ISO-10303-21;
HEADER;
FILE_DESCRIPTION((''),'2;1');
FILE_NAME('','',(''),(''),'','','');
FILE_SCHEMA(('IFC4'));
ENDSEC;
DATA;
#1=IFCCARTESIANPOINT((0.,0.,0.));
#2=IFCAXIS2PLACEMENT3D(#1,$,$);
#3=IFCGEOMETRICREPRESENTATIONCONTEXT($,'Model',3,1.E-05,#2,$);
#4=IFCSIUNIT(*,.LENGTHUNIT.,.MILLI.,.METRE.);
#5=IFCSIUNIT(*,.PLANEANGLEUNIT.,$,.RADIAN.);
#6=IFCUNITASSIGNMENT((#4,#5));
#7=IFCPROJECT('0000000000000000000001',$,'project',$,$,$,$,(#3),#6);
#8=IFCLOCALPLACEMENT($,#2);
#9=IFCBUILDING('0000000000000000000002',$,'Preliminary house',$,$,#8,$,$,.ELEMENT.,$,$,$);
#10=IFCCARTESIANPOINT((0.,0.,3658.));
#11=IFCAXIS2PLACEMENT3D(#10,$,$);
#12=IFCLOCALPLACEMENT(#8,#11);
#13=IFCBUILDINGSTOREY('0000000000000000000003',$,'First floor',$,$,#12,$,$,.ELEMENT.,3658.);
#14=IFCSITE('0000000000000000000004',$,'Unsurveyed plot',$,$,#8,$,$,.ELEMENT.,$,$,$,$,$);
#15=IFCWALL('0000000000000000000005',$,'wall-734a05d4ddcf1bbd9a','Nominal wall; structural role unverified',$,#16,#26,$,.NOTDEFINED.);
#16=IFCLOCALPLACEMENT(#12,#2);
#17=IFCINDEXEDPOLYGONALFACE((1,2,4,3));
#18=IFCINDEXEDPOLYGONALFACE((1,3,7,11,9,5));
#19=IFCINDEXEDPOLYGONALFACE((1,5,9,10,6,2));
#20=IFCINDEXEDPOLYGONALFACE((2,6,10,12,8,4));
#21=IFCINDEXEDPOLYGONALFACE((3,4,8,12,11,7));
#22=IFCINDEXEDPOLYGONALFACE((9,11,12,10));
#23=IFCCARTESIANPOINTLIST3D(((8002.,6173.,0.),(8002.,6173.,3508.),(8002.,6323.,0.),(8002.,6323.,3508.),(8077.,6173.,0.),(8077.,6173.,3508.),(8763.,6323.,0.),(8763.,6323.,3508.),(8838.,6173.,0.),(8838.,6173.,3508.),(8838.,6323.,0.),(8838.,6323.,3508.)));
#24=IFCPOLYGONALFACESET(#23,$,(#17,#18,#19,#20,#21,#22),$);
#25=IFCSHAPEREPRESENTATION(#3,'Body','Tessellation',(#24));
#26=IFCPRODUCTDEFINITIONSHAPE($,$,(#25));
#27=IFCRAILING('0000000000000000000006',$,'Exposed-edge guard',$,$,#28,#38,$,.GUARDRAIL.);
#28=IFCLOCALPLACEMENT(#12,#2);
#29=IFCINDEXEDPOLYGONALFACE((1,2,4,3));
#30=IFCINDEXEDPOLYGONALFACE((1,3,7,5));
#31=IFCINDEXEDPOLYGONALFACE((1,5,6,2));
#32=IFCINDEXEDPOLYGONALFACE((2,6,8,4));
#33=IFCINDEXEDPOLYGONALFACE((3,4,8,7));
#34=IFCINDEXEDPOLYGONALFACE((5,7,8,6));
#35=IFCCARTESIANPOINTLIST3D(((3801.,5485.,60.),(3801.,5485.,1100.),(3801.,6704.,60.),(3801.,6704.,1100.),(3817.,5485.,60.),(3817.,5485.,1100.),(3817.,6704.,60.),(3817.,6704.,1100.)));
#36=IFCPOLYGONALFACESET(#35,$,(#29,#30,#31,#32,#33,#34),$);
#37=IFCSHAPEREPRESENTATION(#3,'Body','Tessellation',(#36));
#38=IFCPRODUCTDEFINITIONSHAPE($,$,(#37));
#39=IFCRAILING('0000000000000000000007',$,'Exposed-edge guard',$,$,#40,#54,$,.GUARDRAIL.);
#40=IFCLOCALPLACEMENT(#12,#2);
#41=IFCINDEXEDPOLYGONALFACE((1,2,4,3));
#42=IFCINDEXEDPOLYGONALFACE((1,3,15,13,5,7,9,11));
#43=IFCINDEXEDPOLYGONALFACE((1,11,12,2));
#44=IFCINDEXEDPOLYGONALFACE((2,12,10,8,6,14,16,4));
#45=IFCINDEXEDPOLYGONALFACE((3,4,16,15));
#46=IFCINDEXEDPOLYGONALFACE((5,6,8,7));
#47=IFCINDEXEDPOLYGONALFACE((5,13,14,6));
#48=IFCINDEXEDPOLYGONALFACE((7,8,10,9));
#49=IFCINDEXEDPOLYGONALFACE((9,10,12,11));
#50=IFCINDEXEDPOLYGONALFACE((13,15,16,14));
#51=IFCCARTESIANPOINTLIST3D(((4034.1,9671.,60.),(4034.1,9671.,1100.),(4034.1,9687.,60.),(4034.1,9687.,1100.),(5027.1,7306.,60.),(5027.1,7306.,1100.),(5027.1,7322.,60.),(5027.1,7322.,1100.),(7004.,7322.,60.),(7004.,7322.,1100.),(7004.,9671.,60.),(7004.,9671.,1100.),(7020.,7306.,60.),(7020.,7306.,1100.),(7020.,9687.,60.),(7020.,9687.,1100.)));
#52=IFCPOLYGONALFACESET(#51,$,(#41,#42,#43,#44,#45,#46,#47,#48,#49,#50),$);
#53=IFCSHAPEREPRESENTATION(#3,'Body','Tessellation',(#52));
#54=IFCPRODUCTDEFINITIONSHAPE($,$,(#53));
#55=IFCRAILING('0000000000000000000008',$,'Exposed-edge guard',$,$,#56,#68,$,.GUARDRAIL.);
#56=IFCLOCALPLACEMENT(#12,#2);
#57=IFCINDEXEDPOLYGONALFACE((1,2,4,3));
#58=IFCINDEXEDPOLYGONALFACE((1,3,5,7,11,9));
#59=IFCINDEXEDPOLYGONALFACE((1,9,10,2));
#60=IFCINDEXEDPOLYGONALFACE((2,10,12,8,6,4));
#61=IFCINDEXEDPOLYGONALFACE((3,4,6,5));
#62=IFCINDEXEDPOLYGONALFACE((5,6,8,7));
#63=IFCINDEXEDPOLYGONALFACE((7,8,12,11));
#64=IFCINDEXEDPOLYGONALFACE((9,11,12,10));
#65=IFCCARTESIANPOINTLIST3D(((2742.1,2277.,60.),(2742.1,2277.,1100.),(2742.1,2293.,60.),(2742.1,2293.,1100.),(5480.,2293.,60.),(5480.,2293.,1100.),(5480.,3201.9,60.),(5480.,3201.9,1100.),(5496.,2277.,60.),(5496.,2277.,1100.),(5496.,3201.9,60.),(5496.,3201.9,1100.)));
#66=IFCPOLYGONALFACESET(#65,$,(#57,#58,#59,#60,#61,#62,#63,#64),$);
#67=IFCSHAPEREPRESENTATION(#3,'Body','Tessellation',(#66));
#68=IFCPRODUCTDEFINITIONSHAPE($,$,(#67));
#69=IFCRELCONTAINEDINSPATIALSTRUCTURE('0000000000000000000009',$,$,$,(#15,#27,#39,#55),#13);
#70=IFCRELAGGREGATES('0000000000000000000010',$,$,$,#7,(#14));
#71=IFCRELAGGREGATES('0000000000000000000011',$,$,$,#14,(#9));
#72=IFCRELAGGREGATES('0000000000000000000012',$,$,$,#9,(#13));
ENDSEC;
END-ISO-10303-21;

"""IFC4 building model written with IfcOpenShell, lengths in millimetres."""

from ifc_helpers import new_model, si_unit, frame, origin, place, context, project, spatial, polyline, outline, extrude, element, save


model = new_model("IFC4")

# Units and contexts
model_context = context("Model", 3, precision=1e-05, world=origin())
ifc_project = project(units=[si_unit("LENGTHUNIT", "METRE", prefix="MILLI"), si_unit("PLANEANGLEUNIT", "RADIAN")], contexts=[model_context])

# Site, building, storey
placement_1 = place(None, origin())
site = spatial("IfcSite", under=ifc_project, at=placement_1, Name="Unsurveyed plot", CompositionType="ELEMENT")
building = spatial("IfcBuilding", under=site, at=placement_1, Name="Preliminary house", CompositionType="ELEMENT")
placement_2 = place(placement_1, frame((0.0, 0.0, 3658.0)))
storey = spatial("IfcBuildingStorey", under=building, at=placement_2, Name="First floor", CompositionType="ELEMENT", Elevation=3658.0)

# Wall
element("IfcWall", 1, at=placement_2, inside=storey, Name="wall-734a05d4ddcf1bbd9a", Description="Nominal wall; structural role unverified", PredefinedType="NOTDEFINED", context=model_context, shape_type="SweptSolid", body=[
    extrude(outline(polyline([(8763.0, 6323.0), (8838.0, 6323.0), (8838.0, 6173.0), (8077.0, 6173.0), (8002.0, 6173.0), (8002.0, 6323.0), (8763.0, 6323.0)])), origin(), (0.0, 0.0, 1.0), 3508.0),
])

# Railings
element("IfcRailing", 2, at=placement_2, inside=storey, Name="Exposed-edge guard", PredefinedType="GUARDRAIL", context=model_context, shape_type="SweptSolid", body=[
    extrude(outline(polyline([(3801.0, 6704.0), (3817.0, 6704.0), (3817.0, 5485.0), (3801.0, 5485.0), (3801.0, 6704.0)])), frame((0.0, 0.0, 60.0)), (0.0, 0.0, 1.0), 1040.0),
])
element("IfcRailing", 3, at=placement_2, inside=storey, Name="Exposed-edge guard", PredefinedType="GUARDRAIL", context=model_context, shape_type="SweptSolid", body=[
    extrude(outline(polyline([(7004.0, 7322.0), (7004.0, 9671.0), (4034.1, 9671.0), (4034.1, 9687.0), (7020.0, 9687.0), (7020.0, 7306.0), (5027.1, 7306.0), (5027.1, 7322.0), (7004.0, 7322.0)])), frame((0.0, 0.0, 60.0)), (0.0, 0.0, 1.0), 1040.0),
])
element("IfcRailing", 4, at=placement_2, inside=storey, Name="Exposed-edge guard", PredefinedType="GUARDRAIL", context=model_context, shape_type="SweptSolid", body=[
    extrude(outline(polyline([(5480.0, 2293.0), (5480.0, 3201.9), (5496.0, 3201.9), (5496.0, 2277.0), (2742.1, 2277.0), (2742.1, 2293.0), (5480.0, 2293.0)])), frame((0.0, 0.0, 60.0)), (0.0, 0.0, 1.0), 1040.0),
])

save(model, "model.ifc")
